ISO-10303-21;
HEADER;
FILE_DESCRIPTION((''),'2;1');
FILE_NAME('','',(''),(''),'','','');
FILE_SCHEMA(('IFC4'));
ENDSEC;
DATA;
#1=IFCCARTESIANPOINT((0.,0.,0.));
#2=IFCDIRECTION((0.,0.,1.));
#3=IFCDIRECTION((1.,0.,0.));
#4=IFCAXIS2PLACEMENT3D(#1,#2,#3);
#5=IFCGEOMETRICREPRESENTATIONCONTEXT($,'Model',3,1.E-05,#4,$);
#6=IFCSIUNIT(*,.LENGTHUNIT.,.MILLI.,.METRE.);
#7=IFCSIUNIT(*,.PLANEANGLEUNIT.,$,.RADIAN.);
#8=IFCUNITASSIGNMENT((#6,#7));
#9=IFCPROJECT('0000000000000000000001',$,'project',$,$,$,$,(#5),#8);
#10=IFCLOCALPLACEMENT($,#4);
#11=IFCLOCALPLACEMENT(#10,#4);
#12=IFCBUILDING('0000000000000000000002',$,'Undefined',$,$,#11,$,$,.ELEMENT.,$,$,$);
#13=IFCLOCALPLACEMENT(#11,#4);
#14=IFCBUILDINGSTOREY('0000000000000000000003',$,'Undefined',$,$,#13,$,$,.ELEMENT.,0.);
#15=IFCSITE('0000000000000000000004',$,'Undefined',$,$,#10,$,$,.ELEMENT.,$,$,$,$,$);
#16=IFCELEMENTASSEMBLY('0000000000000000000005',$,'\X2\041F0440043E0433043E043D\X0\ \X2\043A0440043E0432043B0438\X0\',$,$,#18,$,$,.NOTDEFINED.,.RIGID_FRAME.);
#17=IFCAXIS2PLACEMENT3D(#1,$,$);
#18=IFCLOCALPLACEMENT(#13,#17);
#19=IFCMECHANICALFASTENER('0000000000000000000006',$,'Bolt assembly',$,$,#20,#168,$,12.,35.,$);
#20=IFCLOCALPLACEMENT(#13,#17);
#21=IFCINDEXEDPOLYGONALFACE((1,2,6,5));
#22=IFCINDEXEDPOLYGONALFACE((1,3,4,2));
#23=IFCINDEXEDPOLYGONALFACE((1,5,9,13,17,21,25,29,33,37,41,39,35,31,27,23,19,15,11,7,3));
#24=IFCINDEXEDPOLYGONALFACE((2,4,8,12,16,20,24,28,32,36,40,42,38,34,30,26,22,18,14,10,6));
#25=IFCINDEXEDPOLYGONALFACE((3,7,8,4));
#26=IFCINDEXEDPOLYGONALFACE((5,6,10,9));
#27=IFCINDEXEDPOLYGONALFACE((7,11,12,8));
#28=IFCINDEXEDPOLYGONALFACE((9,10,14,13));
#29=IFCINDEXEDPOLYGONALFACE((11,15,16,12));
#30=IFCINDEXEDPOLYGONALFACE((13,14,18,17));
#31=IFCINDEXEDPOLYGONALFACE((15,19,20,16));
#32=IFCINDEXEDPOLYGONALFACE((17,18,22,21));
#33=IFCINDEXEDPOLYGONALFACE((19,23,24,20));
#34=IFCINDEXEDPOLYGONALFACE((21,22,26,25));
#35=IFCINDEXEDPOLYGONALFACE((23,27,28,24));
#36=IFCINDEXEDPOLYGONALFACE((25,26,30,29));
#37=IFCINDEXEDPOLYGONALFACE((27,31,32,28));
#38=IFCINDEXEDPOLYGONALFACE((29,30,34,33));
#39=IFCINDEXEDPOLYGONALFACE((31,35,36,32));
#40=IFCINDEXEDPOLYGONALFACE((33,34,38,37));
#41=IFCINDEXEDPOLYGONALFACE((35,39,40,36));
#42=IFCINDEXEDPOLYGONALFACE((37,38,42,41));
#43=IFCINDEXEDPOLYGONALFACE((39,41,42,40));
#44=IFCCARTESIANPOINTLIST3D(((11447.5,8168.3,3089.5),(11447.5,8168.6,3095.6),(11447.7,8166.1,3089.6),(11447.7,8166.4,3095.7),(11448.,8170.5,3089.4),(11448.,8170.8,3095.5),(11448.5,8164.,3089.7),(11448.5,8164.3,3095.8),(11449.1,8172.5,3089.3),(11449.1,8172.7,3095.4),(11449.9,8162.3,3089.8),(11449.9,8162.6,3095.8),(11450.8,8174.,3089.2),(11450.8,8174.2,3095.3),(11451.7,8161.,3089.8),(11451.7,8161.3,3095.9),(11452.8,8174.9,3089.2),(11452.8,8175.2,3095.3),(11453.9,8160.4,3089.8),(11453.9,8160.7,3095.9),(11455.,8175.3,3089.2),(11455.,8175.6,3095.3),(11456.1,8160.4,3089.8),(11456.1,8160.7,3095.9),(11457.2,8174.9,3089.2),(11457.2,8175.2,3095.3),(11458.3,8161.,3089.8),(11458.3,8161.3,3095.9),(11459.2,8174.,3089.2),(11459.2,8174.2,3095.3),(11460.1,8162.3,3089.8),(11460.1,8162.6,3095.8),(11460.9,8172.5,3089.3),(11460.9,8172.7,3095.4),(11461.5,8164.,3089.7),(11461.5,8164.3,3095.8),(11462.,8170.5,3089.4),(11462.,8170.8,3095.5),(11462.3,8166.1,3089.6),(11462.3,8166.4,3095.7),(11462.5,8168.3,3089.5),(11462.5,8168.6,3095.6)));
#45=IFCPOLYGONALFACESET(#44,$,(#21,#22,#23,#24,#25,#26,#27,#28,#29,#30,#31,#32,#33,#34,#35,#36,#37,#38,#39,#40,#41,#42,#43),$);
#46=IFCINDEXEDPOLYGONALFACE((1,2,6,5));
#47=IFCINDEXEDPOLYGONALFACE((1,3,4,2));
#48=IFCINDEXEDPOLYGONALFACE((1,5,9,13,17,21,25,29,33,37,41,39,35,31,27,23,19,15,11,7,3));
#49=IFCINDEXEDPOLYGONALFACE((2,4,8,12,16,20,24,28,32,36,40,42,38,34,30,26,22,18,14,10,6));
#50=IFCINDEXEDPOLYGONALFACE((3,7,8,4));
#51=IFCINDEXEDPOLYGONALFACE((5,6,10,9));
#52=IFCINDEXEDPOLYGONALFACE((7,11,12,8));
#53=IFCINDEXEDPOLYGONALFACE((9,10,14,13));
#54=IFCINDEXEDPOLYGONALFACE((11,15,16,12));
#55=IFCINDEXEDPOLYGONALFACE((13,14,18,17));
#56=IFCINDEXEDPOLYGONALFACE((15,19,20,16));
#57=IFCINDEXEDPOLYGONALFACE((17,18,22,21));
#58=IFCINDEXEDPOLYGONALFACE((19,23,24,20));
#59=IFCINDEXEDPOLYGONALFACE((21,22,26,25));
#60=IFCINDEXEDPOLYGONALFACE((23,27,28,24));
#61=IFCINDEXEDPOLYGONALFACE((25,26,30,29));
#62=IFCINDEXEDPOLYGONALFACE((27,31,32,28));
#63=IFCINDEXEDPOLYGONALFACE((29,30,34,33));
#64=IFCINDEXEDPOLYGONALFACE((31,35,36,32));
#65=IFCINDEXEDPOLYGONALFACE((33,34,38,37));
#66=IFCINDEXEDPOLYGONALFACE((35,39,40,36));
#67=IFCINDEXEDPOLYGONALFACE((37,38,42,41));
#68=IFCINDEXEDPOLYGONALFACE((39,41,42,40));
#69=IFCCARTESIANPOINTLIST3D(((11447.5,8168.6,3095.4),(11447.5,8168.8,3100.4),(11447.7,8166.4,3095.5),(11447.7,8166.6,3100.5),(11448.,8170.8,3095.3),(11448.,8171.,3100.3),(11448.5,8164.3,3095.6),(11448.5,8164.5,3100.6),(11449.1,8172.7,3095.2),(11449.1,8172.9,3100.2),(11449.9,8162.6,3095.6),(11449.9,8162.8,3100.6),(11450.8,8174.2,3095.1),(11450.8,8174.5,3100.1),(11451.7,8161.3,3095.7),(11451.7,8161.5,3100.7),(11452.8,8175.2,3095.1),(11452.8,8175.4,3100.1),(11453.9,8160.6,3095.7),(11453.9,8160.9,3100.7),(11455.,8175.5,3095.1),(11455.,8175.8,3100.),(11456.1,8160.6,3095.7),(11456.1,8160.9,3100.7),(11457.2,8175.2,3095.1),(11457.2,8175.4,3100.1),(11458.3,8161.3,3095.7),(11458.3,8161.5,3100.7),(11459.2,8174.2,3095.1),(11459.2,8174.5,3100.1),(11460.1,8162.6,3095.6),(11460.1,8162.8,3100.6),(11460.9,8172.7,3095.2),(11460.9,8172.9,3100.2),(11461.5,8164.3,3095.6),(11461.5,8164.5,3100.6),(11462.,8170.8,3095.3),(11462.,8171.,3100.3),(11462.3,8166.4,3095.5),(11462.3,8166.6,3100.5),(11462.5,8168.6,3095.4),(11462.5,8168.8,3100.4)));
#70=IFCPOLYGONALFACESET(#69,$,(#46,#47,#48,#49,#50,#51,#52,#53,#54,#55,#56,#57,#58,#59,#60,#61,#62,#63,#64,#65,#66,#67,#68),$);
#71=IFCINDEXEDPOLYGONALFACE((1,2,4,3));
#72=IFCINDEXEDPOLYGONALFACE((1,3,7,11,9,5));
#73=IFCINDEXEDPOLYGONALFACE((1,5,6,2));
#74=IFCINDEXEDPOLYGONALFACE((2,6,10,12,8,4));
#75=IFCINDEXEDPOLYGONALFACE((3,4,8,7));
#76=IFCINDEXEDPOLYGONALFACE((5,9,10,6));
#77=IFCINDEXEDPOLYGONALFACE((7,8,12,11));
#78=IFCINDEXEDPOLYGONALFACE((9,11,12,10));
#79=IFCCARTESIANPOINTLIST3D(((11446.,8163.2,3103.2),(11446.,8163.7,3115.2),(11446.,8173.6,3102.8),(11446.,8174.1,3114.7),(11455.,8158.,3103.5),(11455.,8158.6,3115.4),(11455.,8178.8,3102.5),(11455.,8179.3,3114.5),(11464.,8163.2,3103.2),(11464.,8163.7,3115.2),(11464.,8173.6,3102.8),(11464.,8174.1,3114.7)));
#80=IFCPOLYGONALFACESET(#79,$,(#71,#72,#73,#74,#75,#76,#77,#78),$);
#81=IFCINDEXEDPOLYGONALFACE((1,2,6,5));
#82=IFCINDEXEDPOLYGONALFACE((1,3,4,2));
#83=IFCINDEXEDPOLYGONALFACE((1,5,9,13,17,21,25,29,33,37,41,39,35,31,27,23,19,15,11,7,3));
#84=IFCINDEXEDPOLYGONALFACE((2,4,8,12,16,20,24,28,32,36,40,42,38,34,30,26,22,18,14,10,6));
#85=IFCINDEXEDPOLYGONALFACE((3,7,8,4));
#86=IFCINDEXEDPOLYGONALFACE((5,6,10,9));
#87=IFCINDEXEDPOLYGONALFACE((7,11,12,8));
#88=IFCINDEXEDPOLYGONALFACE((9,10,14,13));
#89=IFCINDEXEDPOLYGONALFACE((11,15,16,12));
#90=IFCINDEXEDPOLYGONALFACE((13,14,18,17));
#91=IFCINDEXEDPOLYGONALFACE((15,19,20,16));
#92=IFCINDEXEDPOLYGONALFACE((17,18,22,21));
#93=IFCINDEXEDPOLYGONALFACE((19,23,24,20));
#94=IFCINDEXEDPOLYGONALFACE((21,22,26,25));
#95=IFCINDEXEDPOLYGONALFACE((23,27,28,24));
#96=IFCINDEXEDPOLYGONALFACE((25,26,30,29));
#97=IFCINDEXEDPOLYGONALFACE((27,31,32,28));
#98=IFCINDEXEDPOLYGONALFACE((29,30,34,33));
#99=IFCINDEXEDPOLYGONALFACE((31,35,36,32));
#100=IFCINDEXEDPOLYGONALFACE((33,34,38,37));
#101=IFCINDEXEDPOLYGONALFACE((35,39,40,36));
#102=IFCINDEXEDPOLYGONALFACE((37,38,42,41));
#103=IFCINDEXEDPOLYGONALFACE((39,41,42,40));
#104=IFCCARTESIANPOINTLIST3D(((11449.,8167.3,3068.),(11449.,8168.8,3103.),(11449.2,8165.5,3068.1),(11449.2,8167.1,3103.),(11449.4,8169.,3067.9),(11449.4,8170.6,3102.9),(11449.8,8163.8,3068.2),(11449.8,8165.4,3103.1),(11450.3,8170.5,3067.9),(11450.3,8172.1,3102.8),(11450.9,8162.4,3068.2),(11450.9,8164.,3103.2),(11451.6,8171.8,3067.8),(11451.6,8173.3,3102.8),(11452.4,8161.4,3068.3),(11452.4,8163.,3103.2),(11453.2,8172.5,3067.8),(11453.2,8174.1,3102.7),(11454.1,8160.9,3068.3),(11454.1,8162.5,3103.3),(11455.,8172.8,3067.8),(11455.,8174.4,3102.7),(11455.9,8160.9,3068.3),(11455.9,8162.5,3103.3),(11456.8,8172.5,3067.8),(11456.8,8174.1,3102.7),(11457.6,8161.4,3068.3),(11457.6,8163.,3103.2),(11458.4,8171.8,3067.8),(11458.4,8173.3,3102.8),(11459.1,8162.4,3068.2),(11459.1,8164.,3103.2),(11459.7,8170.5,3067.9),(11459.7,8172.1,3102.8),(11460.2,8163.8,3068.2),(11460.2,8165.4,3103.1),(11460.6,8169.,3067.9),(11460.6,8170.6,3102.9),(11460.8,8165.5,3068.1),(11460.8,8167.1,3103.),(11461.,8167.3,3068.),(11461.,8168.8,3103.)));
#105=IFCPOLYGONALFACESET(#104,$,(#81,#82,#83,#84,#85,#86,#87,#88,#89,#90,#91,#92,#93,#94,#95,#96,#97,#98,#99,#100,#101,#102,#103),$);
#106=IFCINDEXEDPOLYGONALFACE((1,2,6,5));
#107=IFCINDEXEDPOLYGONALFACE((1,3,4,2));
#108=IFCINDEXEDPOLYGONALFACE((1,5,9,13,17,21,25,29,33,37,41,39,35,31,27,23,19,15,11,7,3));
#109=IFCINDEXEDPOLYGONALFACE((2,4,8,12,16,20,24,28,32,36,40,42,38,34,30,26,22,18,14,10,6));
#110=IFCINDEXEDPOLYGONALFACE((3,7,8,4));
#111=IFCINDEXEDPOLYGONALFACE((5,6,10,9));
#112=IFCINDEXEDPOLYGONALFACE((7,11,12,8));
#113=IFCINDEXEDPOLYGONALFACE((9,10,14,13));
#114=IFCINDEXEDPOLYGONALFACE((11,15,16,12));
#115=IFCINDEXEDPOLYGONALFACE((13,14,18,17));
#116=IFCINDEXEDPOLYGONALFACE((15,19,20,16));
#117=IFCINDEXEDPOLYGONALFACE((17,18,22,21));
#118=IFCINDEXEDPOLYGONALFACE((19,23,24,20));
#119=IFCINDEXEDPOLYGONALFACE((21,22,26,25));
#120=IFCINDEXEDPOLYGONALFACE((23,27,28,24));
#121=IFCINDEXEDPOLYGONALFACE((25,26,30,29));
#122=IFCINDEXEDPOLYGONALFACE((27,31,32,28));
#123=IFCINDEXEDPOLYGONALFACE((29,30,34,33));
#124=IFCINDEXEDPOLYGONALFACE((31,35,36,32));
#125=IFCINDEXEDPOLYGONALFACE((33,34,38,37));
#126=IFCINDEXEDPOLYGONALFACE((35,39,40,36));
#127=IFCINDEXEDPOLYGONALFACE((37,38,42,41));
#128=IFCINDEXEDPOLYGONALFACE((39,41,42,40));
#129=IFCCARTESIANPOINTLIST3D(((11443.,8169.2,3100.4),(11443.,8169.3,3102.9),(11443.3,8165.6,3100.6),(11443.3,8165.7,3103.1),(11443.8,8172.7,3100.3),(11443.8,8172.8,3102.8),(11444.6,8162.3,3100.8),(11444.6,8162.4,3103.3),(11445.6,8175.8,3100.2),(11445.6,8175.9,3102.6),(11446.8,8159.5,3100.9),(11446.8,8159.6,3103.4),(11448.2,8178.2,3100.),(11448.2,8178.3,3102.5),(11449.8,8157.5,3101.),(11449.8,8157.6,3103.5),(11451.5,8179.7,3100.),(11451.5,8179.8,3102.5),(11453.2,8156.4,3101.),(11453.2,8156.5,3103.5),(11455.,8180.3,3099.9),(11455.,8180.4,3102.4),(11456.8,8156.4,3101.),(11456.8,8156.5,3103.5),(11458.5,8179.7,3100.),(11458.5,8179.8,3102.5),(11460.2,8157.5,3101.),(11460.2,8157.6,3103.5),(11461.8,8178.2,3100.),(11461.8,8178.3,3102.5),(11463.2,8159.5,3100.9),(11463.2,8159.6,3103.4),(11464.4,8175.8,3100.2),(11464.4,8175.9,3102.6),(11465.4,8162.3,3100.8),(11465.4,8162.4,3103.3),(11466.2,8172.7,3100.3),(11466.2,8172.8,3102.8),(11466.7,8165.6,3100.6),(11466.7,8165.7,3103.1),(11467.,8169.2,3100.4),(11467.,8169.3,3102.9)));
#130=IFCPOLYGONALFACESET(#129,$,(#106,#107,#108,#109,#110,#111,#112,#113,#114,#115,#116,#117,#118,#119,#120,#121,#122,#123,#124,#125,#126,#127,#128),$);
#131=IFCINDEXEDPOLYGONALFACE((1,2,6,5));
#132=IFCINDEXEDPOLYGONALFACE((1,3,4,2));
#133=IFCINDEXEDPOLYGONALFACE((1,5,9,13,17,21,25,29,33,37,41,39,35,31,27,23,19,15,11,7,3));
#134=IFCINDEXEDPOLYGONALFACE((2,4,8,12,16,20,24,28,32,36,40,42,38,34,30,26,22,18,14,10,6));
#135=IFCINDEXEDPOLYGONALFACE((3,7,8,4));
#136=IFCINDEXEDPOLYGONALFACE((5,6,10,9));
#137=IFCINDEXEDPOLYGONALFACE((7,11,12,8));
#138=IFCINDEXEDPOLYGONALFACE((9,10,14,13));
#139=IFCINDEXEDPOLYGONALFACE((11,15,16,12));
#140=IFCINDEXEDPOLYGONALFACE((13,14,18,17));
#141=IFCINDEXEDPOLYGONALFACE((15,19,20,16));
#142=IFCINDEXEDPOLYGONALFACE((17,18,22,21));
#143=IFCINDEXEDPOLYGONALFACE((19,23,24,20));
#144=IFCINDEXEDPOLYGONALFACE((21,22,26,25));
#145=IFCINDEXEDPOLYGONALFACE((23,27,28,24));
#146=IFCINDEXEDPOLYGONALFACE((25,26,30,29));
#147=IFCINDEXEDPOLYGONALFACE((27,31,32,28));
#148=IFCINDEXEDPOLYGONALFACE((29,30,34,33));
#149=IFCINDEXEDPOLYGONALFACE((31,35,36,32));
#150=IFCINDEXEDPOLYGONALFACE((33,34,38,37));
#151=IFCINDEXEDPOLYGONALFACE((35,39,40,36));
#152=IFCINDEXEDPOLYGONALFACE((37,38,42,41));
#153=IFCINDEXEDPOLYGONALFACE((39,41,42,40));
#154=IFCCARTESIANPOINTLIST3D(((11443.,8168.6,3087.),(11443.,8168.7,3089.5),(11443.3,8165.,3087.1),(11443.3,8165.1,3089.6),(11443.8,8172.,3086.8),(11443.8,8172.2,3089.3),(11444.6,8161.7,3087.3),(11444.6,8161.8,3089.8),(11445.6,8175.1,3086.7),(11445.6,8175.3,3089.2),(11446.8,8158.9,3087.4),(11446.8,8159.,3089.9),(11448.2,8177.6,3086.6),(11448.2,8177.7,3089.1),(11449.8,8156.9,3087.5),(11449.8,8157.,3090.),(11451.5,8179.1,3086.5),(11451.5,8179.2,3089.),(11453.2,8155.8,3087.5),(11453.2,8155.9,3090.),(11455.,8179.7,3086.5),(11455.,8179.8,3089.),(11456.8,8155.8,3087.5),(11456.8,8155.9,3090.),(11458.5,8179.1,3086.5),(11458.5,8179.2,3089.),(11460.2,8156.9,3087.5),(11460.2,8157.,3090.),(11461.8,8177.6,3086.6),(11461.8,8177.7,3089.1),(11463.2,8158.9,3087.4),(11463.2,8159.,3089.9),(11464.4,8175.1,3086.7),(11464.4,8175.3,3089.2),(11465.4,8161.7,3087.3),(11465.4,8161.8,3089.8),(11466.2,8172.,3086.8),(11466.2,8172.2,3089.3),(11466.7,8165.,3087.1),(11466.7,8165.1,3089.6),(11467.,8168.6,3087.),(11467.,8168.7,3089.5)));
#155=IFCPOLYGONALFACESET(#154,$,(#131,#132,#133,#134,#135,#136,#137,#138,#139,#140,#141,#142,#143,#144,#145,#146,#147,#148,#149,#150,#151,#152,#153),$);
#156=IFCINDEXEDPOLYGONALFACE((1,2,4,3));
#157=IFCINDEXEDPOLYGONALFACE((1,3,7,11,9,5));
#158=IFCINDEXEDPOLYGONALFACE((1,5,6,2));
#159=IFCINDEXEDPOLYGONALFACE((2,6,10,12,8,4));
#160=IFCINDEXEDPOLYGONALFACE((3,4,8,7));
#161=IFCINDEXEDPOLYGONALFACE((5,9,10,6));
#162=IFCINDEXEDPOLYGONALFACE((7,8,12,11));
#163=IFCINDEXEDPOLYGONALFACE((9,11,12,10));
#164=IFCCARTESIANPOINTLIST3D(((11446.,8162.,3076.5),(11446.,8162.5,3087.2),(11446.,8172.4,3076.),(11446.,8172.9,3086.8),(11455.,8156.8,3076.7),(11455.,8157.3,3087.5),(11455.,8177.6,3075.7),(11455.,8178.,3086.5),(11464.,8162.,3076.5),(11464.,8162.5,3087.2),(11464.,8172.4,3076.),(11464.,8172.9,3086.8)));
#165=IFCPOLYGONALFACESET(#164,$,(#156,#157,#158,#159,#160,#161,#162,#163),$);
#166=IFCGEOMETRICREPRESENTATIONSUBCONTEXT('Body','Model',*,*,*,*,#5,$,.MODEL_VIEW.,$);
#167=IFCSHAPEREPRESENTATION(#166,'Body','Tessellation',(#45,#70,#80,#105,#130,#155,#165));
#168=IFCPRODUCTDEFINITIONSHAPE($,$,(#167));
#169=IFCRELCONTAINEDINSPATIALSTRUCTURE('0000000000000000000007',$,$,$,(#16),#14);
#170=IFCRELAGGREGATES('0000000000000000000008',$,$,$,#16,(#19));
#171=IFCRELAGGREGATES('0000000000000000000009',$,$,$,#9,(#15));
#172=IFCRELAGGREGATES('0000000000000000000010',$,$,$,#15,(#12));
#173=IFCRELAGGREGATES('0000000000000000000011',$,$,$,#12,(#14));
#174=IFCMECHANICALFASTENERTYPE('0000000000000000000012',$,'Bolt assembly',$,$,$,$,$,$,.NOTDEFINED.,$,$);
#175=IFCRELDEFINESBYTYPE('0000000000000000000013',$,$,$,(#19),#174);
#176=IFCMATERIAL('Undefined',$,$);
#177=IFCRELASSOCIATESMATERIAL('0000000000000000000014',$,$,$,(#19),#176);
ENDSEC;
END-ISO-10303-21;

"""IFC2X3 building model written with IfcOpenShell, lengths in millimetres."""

from ifc_helpers import new_model, si_unit, frame, origin_with_axes, origin_2d_with_axis, place, context, subcontext, project, spatial, polyline, circle, outline, extrude, source, transform, mapped, material, type_object, element, aggregate, save


model = new_model("IFC2X3")

# Units and contexts
model_context = context("Model", 3, precision=1e-05, world=origin_with_axes())
body_context = subcontext(model_context, "Body", "Model", "MODEL_VIEW")
ifc_project = project(units=[si_unit("LENGTHUNIT", "METRE", prefix="MILLI"), si_unit("PLANEANGLEUNIT", "RADIAN")], contexts=[model_context])

# Site, building, storey
site_placement = place(None, origin_with_axes())
site = spatial("IfcSite", under=ifc_project, at=site_placement, Name="Undefined", CompositionType="ELEMENT")
building_placement = place(site_placement, origin_with_axes())
building = spatial("IfcBuilding", under=site, at=building_placement, Name="Undefined", CompositionType="ELEMENT")
storey_placement = place(building_placement, origin_with_axes())
storey = spatial("IfcBuildingStorey", under=building, at=storey_placement, Name="Undefined", CompositionType="ELEMENT", Elevation=0.0)

# Element assembly
assembly_1_placement = place(storey_placement, origin_with_axes())
assembly_1 = element("IfcElementAssembly", 1, at=assembly_1_placement, inside=storey, Name="Прогон кровли", AssemblyPlace="NOTDEFINED", PredefinedType="RIGID_FRAME")

# Mechanical fastener
ifc_material_1 = material(Name="Undefined")
mechanical_fastener_type = type_object("IfcMechanicalFastenerType", Name="Bolt assembly")
shared_shape_1 = source(origin_with_axes(), body_context, "Body", "SweptSolid", [
    extrude(circle(Radius=7.5, at=origin_2d_with_axis()), frame((0.0, -0.1, 0.0), z_axis=(0.0, 1.0, 0.0), x_axis=(1.0, 0.0, 0.0)), (0.0, 0.0, 1.0), 6.1),
    extrude(circle(Radius=7.5, at=origin_2d_with_axis()), frame((0.0, -4.9, 0.0), z_axis=(0.0, 1.0, 0.0), x_axis=(1.0, 0.0, 0.0)), (0.0, 0.0, 1.0), 5.0),
    extrude(outline(polyline([(10.4, 0.0), (5.2, 9.0), (-5.2, 9.0), (-10.4, 0.0), (-5.2, -9.0), (5.2, -9.0), (10.4, 0.0)])), frame((0.0, -19.5, 0.0), z_axis=(0.0, 1.0, 0.0), x_axis=(1.0, 0.0, 0.0)), (0.0, 0.0, 1.0), 12.0),
    extrude(circle(Radius=6.0, at=origin_2d_with_axis()), frame((0.0, -7.5, 0.0), z_axis=(0.0, 1.0, 0.0), x_axis=(1.0, 0.0, 0.0)), (0.0, 0.0, 1.0), 35.0),
    extrude(circle(Radius=12.0, at=origin_2d_with_axis()), frame((0.0, -7.5, 0.0), z_axis=(0.0, 1.0, 0.0), x_axis=(1.0, 0.0, 0.0)), (0.0, 0.0, 1.0), 2.5),
    extrude(circle(Radius=12.0, at=origin_2d_with_axis()), frame((0.0, 6.0, 0.0), z_axis=(0.0, 1.0, 0.0), x_axis=(1.0, 0.0, 0.0)), (0.0, 0.0, 1.0), 2.5),
    extrude(outline(polyline([(10.4, 0.0), (5.2, 9.0), (-5.2, 9.0), (-10.4, 0.0), (-5.2, -9.0), (5.2, -9.0), (10.4, 0.0)])), frame((0.0, 8.5, 0.0), z_axis=(0.0, 1.0, 0.0), x_axis=(1.0, 0.0, 0.0)), (0.0, 0.0, 1.0), 10.8),
])
mechanical_fastener_1_placement = place(assembly_1_placement, frame((11455.0, 8168.1, 3095.5), z_axis=(-1.0, 0.0, 0.0), x_axis=(0.0, 0.998969, -0.045408)))
mechanical_fastener_1 = element("IfcMechanicalFastener", 2, at=mechanical_fastener_1_placement, type_object=mechanical_fastener_type, material=ifc_material_1, Name="Bolt assembly", NominalDiameter=12.0, NominalLength=35.0, context=body_context, shape_type="MappedRepresentation", body=[
    mapped(shared_shape_1, transform((0.0, 0.0, 0.0))),
])
aggregate(assembly_1, [mechanical_fastener_1])

save(model, "model.ifc")
